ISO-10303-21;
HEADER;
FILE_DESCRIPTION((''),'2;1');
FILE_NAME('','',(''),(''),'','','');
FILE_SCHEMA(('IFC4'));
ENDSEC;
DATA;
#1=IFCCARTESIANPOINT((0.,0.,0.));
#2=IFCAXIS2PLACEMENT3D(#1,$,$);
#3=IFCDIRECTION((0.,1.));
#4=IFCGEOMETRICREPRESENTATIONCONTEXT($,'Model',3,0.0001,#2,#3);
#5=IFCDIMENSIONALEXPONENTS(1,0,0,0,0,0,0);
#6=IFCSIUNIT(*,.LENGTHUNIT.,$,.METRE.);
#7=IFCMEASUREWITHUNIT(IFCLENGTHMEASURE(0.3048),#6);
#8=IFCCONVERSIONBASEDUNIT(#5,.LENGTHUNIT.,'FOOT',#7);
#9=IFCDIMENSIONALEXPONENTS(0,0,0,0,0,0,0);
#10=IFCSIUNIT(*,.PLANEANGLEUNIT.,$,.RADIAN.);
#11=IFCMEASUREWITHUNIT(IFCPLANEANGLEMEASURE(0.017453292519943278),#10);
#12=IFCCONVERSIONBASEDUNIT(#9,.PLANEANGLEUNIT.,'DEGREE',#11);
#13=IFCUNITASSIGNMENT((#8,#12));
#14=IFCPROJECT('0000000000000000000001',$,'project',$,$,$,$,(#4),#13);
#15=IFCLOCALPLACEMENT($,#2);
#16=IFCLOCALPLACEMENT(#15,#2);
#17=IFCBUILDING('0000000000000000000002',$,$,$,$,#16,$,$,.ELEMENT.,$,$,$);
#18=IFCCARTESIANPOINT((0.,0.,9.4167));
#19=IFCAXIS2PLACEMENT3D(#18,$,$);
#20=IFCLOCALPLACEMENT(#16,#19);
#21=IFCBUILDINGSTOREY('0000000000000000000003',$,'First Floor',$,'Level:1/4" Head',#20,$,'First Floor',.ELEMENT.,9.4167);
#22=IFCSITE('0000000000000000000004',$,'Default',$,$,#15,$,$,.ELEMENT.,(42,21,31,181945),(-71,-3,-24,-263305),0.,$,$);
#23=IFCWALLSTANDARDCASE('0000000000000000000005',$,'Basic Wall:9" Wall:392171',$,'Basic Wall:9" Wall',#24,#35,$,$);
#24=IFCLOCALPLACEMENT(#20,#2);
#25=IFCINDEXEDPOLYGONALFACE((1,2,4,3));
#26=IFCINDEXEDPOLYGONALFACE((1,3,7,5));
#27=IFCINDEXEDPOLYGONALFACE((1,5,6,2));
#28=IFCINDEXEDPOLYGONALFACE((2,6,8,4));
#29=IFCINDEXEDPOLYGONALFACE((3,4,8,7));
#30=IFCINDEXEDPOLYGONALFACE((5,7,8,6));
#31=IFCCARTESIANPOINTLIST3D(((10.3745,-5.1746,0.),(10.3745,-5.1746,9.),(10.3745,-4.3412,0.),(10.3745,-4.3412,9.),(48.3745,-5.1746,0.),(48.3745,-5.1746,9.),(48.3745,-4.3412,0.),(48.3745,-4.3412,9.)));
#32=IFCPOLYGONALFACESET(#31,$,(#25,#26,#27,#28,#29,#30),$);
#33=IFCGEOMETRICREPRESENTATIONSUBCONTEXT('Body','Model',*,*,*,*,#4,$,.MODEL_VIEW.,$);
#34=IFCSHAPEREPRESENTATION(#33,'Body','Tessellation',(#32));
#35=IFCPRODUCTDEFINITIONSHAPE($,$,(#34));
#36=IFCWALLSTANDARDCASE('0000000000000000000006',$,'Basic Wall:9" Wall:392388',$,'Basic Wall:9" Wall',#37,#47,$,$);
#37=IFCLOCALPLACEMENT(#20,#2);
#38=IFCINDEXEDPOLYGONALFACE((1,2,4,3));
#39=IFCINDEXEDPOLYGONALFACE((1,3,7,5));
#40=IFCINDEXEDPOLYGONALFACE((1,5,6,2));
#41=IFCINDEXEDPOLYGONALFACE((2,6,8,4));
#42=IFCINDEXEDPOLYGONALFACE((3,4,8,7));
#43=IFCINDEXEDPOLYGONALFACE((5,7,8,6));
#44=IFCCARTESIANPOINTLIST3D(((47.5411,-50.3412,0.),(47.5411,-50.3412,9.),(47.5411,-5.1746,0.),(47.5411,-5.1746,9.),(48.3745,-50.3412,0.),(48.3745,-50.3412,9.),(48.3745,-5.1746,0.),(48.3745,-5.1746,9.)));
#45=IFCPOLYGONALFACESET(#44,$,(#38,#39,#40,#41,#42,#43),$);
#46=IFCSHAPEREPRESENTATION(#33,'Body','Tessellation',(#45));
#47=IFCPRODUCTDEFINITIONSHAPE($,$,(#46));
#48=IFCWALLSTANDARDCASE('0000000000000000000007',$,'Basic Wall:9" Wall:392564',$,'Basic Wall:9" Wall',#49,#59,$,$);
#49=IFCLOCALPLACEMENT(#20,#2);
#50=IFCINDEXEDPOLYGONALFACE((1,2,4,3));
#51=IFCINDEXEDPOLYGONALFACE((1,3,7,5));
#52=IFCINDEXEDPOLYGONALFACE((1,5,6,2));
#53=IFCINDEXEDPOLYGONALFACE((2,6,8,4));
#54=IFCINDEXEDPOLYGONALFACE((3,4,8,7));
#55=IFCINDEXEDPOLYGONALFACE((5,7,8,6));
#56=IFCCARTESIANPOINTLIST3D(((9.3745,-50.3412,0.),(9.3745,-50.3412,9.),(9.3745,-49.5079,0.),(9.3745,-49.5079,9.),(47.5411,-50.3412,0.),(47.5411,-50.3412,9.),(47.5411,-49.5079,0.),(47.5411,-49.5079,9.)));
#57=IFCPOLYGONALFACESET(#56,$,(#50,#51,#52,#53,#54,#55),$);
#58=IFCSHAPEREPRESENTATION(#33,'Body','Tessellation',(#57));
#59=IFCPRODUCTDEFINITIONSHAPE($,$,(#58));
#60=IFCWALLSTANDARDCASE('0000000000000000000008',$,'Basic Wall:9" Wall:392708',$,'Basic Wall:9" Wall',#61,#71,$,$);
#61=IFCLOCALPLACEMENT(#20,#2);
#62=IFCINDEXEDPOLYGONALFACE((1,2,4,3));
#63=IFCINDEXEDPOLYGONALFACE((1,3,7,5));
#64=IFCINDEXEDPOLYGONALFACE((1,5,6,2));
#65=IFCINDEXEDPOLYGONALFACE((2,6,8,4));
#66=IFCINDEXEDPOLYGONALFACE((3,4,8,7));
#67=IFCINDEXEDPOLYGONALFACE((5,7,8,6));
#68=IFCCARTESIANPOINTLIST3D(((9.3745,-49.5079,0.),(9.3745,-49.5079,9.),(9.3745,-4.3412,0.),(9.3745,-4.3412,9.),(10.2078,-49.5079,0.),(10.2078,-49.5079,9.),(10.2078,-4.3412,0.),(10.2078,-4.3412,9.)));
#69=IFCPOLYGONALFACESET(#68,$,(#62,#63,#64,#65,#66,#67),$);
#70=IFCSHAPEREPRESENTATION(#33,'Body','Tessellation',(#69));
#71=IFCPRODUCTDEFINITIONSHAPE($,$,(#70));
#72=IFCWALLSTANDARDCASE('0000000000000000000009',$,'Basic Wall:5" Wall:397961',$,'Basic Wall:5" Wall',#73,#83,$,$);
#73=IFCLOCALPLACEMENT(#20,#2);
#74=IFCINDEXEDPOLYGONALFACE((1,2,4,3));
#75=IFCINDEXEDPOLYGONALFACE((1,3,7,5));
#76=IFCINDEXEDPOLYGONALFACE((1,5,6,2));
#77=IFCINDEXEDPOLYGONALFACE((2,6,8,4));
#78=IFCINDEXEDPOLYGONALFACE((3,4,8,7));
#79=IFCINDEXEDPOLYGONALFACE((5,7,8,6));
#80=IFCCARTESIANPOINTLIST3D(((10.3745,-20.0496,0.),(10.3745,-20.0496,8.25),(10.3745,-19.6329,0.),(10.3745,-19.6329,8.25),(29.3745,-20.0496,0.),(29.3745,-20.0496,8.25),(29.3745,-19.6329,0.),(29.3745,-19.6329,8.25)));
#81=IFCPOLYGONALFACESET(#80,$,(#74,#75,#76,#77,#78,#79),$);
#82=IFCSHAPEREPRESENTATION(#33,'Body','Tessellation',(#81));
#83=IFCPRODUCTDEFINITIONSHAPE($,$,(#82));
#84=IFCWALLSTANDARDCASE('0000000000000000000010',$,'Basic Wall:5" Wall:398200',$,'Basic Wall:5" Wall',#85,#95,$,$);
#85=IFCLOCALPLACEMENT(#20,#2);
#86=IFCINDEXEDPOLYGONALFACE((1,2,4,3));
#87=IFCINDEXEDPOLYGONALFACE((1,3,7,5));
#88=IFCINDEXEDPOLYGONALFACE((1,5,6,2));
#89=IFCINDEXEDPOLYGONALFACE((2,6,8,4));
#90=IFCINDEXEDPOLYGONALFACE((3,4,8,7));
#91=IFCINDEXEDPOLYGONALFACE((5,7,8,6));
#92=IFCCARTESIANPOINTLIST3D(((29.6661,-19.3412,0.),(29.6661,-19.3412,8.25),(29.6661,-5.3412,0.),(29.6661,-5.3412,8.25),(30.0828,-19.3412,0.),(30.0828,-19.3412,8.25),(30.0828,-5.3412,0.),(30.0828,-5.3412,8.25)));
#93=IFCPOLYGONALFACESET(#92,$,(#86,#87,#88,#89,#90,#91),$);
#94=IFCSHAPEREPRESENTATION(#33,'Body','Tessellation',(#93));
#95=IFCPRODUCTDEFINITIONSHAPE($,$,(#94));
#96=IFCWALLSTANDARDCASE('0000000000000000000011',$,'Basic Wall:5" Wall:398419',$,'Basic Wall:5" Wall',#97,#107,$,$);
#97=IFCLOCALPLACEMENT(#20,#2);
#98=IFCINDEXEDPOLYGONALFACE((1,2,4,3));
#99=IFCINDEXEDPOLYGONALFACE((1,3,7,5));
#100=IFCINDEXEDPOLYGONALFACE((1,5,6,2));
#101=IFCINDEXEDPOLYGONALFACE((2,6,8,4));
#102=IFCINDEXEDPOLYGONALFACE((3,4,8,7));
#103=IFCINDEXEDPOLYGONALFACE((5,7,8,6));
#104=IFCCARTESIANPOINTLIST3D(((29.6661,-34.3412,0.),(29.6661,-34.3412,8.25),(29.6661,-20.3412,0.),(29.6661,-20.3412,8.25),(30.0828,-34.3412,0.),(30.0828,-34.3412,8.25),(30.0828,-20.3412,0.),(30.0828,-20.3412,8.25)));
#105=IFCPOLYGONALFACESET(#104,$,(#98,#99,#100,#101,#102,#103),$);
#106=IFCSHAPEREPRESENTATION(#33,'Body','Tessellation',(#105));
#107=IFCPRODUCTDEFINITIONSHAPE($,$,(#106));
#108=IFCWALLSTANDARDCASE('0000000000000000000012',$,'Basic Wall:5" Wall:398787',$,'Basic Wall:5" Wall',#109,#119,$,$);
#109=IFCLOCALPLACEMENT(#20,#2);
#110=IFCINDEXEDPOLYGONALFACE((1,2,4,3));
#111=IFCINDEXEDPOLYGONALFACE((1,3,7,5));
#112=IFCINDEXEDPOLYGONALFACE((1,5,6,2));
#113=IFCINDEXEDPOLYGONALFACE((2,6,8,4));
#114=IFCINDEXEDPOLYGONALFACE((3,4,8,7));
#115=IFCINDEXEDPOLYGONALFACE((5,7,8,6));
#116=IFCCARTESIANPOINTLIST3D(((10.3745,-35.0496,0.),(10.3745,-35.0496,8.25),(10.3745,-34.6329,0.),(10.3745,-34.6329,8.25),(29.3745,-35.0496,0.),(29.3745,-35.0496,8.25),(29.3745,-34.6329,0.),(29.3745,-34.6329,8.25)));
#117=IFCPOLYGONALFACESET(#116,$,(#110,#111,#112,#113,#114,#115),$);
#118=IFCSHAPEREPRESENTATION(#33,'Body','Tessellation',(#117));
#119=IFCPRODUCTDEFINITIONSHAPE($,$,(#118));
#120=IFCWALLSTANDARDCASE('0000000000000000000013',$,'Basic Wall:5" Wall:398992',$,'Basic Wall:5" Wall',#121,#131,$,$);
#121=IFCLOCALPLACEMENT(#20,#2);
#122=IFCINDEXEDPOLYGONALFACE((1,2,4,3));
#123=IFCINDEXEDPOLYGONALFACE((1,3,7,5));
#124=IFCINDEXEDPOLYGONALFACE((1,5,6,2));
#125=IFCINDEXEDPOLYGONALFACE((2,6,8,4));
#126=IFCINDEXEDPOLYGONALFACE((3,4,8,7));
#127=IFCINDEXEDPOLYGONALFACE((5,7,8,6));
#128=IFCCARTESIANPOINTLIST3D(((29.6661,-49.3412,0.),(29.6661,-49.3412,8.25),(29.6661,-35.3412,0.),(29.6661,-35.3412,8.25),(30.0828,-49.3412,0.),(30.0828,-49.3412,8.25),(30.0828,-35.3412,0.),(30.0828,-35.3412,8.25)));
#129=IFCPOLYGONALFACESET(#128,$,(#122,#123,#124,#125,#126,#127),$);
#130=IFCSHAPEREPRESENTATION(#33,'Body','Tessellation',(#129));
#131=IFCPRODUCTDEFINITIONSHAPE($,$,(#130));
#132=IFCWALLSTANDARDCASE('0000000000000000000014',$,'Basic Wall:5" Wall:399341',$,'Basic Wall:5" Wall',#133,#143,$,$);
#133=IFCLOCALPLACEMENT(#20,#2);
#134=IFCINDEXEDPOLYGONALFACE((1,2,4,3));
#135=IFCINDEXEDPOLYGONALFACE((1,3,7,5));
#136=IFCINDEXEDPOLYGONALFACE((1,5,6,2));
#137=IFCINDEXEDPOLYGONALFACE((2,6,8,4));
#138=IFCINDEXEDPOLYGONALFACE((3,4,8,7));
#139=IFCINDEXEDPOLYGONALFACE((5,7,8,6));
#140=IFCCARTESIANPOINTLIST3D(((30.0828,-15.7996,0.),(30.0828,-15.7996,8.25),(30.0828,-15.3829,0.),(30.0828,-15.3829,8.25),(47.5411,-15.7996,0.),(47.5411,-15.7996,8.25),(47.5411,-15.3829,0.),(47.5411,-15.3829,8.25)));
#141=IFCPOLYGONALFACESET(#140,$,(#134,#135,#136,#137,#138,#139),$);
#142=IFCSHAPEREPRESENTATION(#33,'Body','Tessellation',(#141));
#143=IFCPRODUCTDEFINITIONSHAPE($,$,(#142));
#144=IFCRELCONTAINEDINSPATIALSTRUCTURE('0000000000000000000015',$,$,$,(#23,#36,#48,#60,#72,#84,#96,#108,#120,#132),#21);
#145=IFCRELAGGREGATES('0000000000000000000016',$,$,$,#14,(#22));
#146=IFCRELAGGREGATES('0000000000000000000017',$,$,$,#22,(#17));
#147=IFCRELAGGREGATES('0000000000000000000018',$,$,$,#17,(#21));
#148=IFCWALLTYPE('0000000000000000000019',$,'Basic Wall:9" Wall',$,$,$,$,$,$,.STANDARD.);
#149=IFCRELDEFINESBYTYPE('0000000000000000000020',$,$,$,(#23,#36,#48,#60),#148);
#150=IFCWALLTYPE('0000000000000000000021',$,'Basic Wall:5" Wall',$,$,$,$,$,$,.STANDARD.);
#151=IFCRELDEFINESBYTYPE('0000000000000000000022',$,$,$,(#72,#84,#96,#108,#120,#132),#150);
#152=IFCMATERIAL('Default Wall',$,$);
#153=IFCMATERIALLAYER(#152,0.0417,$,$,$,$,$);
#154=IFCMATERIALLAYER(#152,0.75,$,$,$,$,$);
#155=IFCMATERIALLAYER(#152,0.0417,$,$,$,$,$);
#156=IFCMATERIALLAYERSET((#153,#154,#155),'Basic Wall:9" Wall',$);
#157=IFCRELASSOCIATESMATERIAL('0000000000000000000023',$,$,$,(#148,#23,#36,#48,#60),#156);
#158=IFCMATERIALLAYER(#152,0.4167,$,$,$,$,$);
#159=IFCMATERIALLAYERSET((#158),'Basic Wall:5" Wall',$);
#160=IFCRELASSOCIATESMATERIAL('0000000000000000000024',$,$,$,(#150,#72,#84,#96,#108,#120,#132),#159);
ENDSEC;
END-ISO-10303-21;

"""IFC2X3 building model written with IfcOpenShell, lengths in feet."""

from ifc_helpers import new_model, entity, si_unit, converted_unit, direction, frame, frame_2d, origin, place, context, subcontext, project, spatial, rectangle, extrude, material, layer, layer_set, layer_usage, type_object, element, save


model = new_model("IFC2X3")

# Units and contexts
model_context = context("Model", 3, precision=0.0001, world=origin(), true_north=direction((0.0, 1.0)))
body_context = subcontext(model_context, "Body", "Model", "MODEL_VIEW")
ifc_project = project(units=[converted_unit("LENGTHUNIT", "FOOT", entity("IfcLengthMeasure", 0.3048), si_unit("LENGTHUNIT", "METRE"), dimensions=[1, 0, 0, 0, 0, 0, 0]), converted_unit("PLANEANGLEUNIT", "DEGREE", entity("IfcPlaneAngleMeasure", 0.017453292519943278), si_unit("PLANEANGLEUNIT", "RADIAN"), dimensions=[0, 0, 0, 0, 0, 0, 0])], contexts=[model_context])

# Site, building, storey
site_placement = place(None, origin())
site = spatial("IfcSite", under=ifc_project, at=site_placement, Name="Default", CompositionType="ELEMENT", RefLatitude=(42, 21, 31, 181945), RefLongitude=(-71, -3, -24, -263305), RefElevation=0.0)
building_placement = place(site_placement, origin())
building = spatial("IfcBuilding", under=site, at=building_placement, CompositionType="ELEMENT")
storey_placement = place(building_placement, frame((0.0, 0.0, 9.4167)))
storey = spatial("IfcBuildingStorey", under=building, at=storey_placement, Name="First Floor", ObjectType="Level:1/4\" Head", LongName="First Floor", CompositionType="ELEMENT", Elevation=9.4167)

# Walls
ifc_material_1 = material(Name="Default Wall")
ifc_layer_1 = layer(ifc_material_1, 0.0417)
ifc_layer_2 = layer(ifc_material_1, 0.75)
ifc_layer_3 = layer(ifc_material_1, 0.0417)
ifc_layer_set_1 = layer_set([ifc_layer_1, ifc_layer_2, ifc_layer_3], Name="Basic Wall:9\" Wall")
ifc_layer_usage_1 = layer_usage(ifc_layer_set_1, "AXIS2", "NEGATIVE", 0.4167)
wall_type_1 = type_object("IfcWallType", Name="Basic Wall:9\" Wall", PredefinedType="STANDARD", material=ifc_layer_set_1)
wall_1_placement = place(storey_placement, frame((10.3745, -4.7579, 0.0)))
element("IfcWallStandardCase", 1, at=wall_1_placement, inside=storey, type_object=wall_type_1, material=ifc_layer_usage_1, Name="Basic Wall:9\" Wall:392171", ObjectType="Basic Wall:9\" Wall", context=body_context, shape_type="SweptSolid", body=[
    extrude(rectangle(XDim=38.0, YDim=0.8333, at=frame_2d((19.0, 0.0), x_axis=(-1.0, 0.0))), origin(), (0.0, 0.0, 1.0), 9.0),
])
wall_2_placement = place(storey_placement, frame((47.9578, -5.1746, 0.0), z_axis=(0.0, 0.0, 1.0), x_axis=(0.0, -1.0, 0.0)))
element("IfcWallStandardCase", 2, at=wall_2_placement, inside=storey, type_object=wall_type_1, material=ifc_layer_usage_1, Name="Basic Wall:9\" Wall:392388", ObjectType="Basic Wall:9\" Wall", context=body_context, shape_type="SweptSolid", body=[
    extrude(rectangle(XDim=45.1667, YDim=0.8333, at=frame_2d((22.5833, 0.0), x_axis=(-1.0, 0.0))), origin(), (0.0, 0.0, 1.0), 9.0),
])
wall_3_placement = place(storey_placement, frame((47.5411, -49.9246, 0.0), z_axis=(0.0, 0.0, 1.0), x_axis=(-1.0, 0.0, 0.0)))
element("IfcWallStandardCase", 3, at=wall_3_placement, inside=storey, type_object=wall_type_1, material=ifc_layer_usage_1, Name="Basic Wall:9\" Wall:392564", ObjectType="Basic Wall:9\" Wall", context=body_context, shape_type="SweptSolid", body=[
    extrude(rectangle(XDim=38.1667, YDim=0.8333, at=frame_2d((19.0833, 0.0), x_axis=(-1.0, 0.0))), origin(), (0.0, 0.0, 1.0), 9.0),
])
wall_4_placement = place(storey_placement, frame((9.7911, -49.5079, 0.0), z_axis=(0.0, 0.0, 1.0), x_axis=(0.0, 1.0, 0.0)))
element("IfcWallStandardCase", 4, at=wall_4_placement, inside=storey, type_object=wall_type_1, material=ifc_layer_usage_1, Name="Basic Wall:9\" Wall:392708", ObjectType="Basic Wall:9\" Wall", context=body_context, shape_type="SweptSolid", body=[
    extrude(rectangle(XDim=45.1667, YDim=0.8333, at=frame_2d((22.5833, 0.0), x_axis=(-1.0, 0.0))), origin(), (0.0, 0.0, 1.0), 9.0),
])
ifc_layer_4 = layer(ifc_material_1, 0.4167)
ifc_layer_set_2 = layer_set([ifc_layer_4], Name="Basic Wall:5\" Wall")
ifc_layer_usage_2 = layer_usage(ifc_layer_set_2, "AXIS2", "NEGATIVE", 0.2083)
wall_type_2 = type_object("IfcWallType", Name="Basic Wall:5\" Wall", PredefinedType="STANDARD", material=ifc_layer_set_2)
wall_5_placement = place(storey_placement, frame((10.3745, -19.8412, 0.0)))
element("IfcWallStandardCase", 5, at=wall_5_placement, inside=storey, type_object=wall_type_2, material=ifc_layer_usage_2, Name="Basic Wall:5\" Wall:397961", ObjectType="Basic Wall:5\" Wall", context=body_context, shape_type="SweptSolid", body=[
    extrude(rectangle(XDim=19.0, YDim=0.4167, at=frame_2d((9.5, 0.0), x_axis=(-1.0, 0.0))), origin(), (0.0, 0.0, 1.0), 8.25),
])
wall_6_placement = place(storey_placement, frame((29.8745, -19.3412, 0.0), z_axis=(0.0, 0.0, 1.0), x_axis=(0.0, 1.0, 0.0)))
element("IfcWallStandardCase", 6, at=wall_6_placement, inside=storey, type_object=wall_type_2, material=ifc_layer_usage_2, Name="Basic Wall:5\" Wall:398200", ObjectType="Basic Wall:5\" Wall", context=body_context, shape_type="SweptSolid", body=[
    extrude(rectangle(XDim=14.0, YDim=0.4167, at=frame_2d((7.0, 0.0), x_axis=(-1.0, 0.0))), origin(), (0.0, 0.0, 1.0), 8.25),
])
wall_7_placement = place(storey_placement, frame((29.8745, -20.3412, 0.0), z_axis=(0.0, 0.0, 1.0), x_axis=(0.0, -1.0, 0.0)))
element("IfcWallStandardCase", 7, at=wall_7_placement, inside=storey, type_object=wall_type_2, material=ifc_layer_usage_2, Name="Basic Wall:5\" Wall:398419", ObjectType="Basic Wall:5\" Wall", context=body_context, shape_type="SweptSolid", body=[
    extrude(rectangle(XDim=14.0, YDim=0.4167, at=frame_2d((7.0, 0.0), x_axis=(-1.0, 0.0))), origin(), (0.0, 0.0, 1.0), 8.25),
])
wall_8_placement = place(storey_placement, frame((29.3745, -34.8412, 0.0), z_axis=(0.0, 0.0, 1.0), x_axis=(-1.0, 0.0, 0.0)))
element("IfcWallStandardCase", 8, at=wall_8_placement, inside=storey, type_object=wall_type_2, material=ifc_layer_usage_2, Name="Basic Wall:5\" Wall:398787", ObjectType="Basic Wall:5\" Wall", context=body_context, shape_type="SweptSolid", body=[
    extrude(rectangle(XDim=19.0, YDim=0.4167, at=frame_2d((9.5, 0.0), x_axis=(-1.0, 0.0))), origin(), (0.0, 0.0, 1.0), 8.25),
])
wall_9_placement = place(storey_placement, frame((29.8745, -35.3412, 0.0), z_axis=(0.0, 0.0, 1.0), x_axis=(0.0, -1.0, 0.0)))
element("IfcWallStandardCase", 9, at=wall_9_placement, inside=storey, type_object=wall_type_2, material=ifc_layer_usage_2, Name="Basic Wall:5\" Wall:398992", ObjectType="Basic Wall:5\" Wall", context=body_context, shape_type="SweptSolid", body=[
    extrude(rectangle(XDim=14.0, YDim=0.4167, at=frame_2d((7.0, 0.0), x_axis=(-1.0, 0.0))), origin(), (0.0, 0.0, 1.0), 8.25),
])
wall_10_placement = place(storey_placement, frame((30.0828, -15.5912, 0.0)))
element("IfcWallStandardCase", 10, at=wall_10_placement, inside=storey, type_object=wall_type_2, material=ifc_layer_usage_2, Name="Basic Wall:5\" Wall:399341", ObjectType="Basic Wall:5\" Wall", context=body_context, shape_type="SweptSolid", body=[
    extrude(rectangle(XDim=17.4583, YDim=0.4167, at=frame_2d((8.7292, 0.0), x_axis=(-1.0, 0.0))), origin(), (0.0, 0.0, 1.0), 8.25),
])

save(model, "model.ifc")
